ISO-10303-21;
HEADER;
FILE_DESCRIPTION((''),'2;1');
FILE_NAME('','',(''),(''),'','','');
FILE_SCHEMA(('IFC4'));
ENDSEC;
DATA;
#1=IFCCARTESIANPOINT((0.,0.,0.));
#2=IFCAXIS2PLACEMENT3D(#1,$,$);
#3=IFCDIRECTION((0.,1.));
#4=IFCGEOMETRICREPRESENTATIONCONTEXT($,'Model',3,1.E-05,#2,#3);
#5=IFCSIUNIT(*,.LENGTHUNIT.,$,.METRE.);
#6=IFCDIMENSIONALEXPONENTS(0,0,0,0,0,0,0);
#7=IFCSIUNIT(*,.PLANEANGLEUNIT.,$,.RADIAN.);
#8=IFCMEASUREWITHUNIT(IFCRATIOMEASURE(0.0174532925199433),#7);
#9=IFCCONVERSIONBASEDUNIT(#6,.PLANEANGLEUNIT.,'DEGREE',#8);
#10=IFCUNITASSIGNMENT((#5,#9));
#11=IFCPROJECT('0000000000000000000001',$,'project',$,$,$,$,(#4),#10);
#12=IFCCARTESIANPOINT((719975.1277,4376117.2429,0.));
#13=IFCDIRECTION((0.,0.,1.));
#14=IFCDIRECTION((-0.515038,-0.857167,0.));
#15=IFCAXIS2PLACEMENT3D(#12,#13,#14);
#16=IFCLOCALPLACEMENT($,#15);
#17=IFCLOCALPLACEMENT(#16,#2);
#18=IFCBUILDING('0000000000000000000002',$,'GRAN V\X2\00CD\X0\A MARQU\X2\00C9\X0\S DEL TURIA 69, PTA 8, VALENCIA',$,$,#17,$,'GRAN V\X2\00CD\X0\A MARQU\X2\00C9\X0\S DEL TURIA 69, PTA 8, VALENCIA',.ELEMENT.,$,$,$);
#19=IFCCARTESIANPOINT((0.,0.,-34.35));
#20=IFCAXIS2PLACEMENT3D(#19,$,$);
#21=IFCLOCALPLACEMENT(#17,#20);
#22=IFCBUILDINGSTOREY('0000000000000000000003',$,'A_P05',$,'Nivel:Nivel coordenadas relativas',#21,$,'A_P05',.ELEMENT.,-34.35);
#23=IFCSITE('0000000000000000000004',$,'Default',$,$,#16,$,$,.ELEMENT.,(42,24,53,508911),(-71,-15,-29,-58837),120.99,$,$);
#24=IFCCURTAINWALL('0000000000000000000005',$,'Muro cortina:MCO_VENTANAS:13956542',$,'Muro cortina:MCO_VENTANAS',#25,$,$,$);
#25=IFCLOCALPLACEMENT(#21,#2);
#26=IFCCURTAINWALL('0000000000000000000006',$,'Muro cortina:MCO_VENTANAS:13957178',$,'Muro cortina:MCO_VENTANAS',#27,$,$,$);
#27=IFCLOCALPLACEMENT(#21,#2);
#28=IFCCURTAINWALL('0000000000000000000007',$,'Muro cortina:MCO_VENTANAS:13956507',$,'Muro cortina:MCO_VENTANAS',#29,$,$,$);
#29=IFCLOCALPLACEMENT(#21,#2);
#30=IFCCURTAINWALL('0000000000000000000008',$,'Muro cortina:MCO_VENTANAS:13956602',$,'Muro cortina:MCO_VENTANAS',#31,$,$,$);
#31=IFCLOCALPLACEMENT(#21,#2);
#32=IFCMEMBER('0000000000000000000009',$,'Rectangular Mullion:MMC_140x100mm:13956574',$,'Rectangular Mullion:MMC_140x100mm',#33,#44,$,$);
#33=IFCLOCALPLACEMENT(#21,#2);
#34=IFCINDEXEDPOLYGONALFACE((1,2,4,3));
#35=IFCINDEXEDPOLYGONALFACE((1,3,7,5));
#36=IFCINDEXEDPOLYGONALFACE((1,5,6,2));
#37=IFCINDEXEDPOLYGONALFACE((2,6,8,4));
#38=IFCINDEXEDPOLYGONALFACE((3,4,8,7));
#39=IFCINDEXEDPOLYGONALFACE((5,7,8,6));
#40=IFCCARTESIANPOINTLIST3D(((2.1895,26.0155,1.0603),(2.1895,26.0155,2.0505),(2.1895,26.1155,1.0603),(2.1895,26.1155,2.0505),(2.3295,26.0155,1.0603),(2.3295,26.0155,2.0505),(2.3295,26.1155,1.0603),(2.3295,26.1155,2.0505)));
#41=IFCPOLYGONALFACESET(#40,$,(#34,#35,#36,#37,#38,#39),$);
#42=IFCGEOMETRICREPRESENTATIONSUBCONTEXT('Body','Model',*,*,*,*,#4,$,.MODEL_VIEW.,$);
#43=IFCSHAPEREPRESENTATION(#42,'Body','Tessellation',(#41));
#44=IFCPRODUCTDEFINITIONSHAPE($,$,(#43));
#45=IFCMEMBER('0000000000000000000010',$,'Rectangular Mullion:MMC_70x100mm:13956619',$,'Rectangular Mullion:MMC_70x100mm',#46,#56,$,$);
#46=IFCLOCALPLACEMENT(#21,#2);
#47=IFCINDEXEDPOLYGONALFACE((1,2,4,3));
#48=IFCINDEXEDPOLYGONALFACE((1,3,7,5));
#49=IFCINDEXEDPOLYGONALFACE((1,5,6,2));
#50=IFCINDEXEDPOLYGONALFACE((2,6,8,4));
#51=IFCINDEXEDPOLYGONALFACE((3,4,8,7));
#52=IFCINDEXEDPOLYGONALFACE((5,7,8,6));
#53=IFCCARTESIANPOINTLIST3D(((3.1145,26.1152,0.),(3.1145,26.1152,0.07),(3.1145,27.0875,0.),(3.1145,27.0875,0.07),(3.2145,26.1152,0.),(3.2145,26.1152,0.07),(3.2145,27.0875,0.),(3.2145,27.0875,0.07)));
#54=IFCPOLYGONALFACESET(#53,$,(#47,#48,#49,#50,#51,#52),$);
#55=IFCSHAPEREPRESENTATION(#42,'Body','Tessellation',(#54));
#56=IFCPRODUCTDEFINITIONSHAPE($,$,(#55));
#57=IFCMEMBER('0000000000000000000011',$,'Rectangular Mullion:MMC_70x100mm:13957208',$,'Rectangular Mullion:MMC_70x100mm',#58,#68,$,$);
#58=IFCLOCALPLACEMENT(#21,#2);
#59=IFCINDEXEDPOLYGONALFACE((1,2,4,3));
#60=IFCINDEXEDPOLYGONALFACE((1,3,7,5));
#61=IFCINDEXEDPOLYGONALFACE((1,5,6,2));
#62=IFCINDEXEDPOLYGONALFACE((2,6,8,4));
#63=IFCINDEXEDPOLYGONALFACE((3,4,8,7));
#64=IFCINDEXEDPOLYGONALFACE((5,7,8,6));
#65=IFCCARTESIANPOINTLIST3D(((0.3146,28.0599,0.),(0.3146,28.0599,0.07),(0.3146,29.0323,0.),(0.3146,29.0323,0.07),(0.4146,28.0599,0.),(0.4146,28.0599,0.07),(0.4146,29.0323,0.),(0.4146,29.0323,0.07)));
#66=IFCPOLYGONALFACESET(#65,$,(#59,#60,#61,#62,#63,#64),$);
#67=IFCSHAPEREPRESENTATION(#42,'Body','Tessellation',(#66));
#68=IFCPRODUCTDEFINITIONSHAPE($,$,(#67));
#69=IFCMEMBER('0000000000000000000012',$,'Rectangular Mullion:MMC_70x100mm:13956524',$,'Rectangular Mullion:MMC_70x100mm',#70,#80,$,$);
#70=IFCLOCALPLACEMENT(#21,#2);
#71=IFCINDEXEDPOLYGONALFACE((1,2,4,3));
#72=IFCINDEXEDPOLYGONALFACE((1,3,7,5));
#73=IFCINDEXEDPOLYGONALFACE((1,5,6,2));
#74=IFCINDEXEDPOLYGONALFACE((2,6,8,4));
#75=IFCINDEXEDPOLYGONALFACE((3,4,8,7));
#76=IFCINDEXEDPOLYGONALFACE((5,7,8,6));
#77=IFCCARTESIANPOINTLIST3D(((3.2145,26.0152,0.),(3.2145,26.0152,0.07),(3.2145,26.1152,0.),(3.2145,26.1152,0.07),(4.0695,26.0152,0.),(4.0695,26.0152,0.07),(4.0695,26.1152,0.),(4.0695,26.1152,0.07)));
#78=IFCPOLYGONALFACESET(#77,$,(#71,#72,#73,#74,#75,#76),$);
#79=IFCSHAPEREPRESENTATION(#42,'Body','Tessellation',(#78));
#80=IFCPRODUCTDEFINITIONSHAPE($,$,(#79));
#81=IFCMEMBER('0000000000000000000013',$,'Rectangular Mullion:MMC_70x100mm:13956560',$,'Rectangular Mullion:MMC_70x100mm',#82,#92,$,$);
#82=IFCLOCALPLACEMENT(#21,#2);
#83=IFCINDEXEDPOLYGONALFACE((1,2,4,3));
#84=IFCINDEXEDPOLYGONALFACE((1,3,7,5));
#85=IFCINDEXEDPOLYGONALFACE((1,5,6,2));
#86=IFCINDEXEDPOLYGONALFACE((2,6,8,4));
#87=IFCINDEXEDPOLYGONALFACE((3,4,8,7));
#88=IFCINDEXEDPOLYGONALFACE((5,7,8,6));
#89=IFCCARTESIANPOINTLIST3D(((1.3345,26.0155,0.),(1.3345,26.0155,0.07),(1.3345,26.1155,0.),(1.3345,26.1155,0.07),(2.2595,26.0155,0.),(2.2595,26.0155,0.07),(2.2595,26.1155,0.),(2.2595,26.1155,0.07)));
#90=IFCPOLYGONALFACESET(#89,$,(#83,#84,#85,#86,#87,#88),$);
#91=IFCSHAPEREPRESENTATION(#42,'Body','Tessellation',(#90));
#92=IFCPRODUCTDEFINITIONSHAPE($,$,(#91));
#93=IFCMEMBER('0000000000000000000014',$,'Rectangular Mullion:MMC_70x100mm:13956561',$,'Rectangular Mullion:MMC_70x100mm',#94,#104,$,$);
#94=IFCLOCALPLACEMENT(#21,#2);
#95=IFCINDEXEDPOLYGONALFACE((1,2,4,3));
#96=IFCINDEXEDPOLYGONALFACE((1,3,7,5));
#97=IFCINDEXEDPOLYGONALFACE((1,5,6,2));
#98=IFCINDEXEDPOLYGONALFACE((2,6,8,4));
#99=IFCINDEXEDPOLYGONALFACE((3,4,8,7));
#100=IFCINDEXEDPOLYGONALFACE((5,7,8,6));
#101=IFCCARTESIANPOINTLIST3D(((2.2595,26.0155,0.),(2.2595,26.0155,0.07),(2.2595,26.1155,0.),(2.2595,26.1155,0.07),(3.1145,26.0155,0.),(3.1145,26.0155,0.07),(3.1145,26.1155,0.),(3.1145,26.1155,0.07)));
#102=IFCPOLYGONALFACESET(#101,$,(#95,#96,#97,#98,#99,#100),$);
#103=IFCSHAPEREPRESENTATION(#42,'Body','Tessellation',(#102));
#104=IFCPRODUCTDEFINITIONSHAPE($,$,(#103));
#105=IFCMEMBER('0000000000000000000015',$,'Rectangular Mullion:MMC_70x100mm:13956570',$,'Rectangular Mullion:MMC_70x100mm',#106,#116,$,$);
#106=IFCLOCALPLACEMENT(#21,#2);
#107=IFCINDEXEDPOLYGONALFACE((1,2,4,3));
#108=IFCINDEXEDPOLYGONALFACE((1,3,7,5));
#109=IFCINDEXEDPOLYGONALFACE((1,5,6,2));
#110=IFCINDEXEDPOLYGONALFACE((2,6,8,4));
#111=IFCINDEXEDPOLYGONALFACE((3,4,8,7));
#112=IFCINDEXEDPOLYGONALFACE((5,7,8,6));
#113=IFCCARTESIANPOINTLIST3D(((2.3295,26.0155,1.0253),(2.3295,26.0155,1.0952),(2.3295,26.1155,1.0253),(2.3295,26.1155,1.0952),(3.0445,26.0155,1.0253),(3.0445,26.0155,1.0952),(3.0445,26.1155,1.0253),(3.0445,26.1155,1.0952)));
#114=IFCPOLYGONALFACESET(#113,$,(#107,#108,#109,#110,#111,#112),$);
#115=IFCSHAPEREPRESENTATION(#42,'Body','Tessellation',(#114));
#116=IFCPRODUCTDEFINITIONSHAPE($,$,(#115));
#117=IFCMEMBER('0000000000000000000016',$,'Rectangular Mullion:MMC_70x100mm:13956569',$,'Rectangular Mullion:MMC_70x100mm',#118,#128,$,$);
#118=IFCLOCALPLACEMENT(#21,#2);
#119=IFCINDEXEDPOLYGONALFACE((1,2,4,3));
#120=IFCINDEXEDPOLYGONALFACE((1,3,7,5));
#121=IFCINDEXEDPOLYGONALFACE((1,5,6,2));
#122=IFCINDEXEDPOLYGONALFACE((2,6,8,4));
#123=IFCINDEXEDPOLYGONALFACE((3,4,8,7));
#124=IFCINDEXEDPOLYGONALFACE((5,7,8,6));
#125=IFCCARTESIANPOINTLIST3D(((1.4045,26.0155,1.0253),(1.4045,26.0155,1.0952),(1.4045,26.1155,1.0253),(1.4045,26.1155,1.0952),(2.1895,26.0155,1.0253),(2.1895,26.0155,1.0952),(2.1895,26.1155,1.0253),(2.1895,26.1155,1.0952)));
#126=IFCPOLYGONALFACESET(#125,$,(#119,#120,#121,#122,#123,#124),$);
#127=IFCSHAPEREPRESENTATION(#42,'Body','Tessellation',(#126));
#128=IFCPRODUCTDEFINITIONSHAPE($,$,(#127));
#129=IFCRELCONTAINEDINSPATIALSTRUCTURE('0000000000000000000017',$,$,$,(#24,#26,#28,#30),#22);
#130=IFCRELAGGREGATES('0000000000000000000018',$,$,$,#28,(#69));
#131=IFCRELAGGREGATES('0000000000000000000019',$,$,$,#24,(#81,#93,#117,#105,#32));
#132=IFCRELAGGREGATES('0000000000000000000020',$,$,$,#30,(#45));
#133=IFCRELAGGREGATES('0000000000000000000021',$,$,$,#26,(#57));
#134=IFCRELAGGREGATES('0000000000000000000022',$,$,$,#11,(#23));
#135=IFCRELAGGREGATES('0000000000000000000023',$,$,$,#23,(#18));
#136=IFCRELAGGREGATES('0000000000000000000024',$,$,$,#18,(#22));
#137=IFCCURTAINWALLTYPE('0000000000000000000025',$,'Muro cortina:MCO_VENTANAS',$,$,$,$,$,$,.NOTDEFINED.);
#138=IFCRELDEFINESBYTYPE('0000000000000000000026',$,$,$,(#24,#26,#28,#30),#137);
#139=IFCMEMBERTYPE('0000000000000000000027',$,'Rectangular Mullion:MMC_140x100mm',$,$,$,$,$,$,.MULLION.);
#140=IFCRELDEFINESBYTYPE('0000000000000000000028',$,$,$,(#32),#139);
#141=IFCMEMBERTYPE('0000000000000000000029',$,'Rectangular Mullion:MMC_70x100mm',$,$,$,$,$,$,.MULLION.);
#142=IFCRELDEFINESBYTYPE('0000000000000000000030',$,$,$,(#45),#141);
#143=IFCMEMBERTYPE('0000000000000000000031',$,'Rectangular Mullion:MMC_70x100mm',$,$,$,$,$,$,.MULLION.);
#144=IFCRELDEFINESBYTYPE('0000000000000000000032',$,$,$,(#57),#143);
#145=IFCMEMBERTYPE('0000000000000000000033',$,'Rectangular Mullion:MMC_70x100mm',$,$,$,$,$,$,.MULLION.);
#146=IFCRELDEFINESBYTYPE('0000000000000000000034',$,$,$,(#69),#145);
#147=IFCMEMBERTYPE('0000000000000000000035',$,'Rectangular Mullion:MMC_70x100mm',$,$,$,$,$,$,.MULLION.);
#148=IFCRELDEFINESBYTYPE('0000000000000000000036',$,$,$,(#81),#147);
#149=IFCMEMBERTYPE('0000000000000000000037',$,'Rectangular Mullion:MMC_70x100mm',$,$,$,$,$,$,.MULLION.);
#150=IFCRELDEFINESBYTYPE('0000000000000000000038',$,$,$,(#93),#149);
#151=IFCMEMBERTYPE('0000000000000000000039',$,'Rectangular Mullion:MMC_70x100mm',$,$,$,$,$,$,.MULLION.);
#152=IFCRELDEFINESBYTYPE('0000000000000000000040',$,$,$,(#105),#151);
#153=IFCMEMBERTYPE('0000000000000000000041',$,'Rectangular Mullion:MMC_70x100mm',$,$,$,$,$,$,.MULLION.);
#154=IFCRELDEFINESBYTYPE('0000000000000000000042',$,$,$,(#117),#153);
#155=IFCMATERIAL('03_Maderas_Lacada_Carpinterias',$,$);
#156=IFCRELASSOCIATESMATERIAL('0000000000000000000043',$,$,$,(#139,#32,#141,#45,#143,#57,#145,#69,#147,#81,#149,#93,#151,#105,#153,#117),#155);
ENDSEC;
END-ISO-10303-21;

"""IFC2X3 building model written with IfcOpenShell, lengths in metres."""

from ifc_helpers import new_model, entity, si_unit, converted_unit, direction, frame, origin, origin_2d_with_axis, place, context, subcontext, project, spatial, rectangle, extrude, source, transform, mapped, material, type_object, type_shapes, element, aggregate, save


model = new_model("IFC2X3")

# Units and contexts
model_context = context("Model", 3, precision=1e-05, world=origin(), true_north=direction((0.0, 1.0)))
body_context = subcontext(model_context, "Body", "Model", "MODEL_VIEW")
ifc_project = project(units=[si_unit("LENGTHUNIT", "METRE"), converted_unit("PLANEANGLEUNIT", "DEGREE", entity("IfcRatioMeasure", 0.0174532925199433), si_unit("PLANEANGLEUNIT", "RADIAN"), dimensions=[0, 0, 0, 0, 0, 0, 0])], contexts=[model_context])

# Site, building, storey
site_placement = place(None, frame((719975.1277, 4376117.2429, 0.0), z_axis=(0.0, 0.0, 1.0), x_axis=(-0.515038, -0.857167, 0.0)))
site = spatial("IfcSite", under=ifc_project, at=site_placement, Name="Default", CompositionType="ELEMENT", RefLatitude=(42, 24, 53, 508911), RefLongitude=(-71, -15, -29, -58837), RefElevation=120.99)
building_placement = place(site_placement, origin())
building = spatial("IfcBuilding", under=site, at=building_placement, Name="GRAN VÍA MARQUÉS DEL TURIA 69, PTA 8, VALENCIA", LongName="GRAN VÍA MARQUÉS DEL TURIA 69, PTA 8, VALENCIA", CompositionType="ELEMENT")
storey_placement = place(building_placement, frame((0.0, 0.0, -34.35)))
storey = spatial("IfcBuildingStorey", under=building, at=storey_placement, Name="A_P05", ObjectType="Nivel:Nivel coordenadas relativas", LongName="A_P05", CompositionType="ELEMENT", Elevation=-34.35)

# Shared definitions
curtain_wall_type = type_object("IfcCurtainWallType", Name="Muro cortina:MCO_VENTANAS", PredefinedType="NOTDEFINED")
ifc_material_1 = material(Name="03_Maderas_Lacada_Carpinterias")

# Curtain walls
curtain_wall_1_placement = place(storey_placement, frame((0.0, 0.0, 34.35)))
curtain_wall_1 = element("IfcCurtainWall", 1, at=curtain_wall_1_placement, inside=storey, type_object=curtain_wall_type, Name="Muro cortina:MCO_VENTANAS:13956542", ObjectType="Muro cortina:MCO_VENTANAS")
curtain_wall_2_placement = place(storey_placement, frame((0.0, 0.0, 34.35)))
curtain_wall_2 = element("IfcCurtainWall", 2, at=curtain_wall_2_placement, inside=storey, type_object=curtain_wall_type, Name="Muro cortina:MCO_VENTANAS:13957178", ObjectType="Muro cortina:MCO_VENTANAS")
curtain_wall_3_placement = place(storey_placement, frame((0.0, 0.0, 34.35)))
curtain_wall_3 = element("IfcCurtainWall", 3, at=curtain_wall_3_placement, inside=storey, type_object=curtain_wall_type, Name="Muro cortina:MCO_VENTANAS:13956507", ObjectType="Muro cortina:MCO_VENTANAS")
curtain_wall_4_placement = place(storey_placement, frame((0.0, 0.0, 34.35)))
curtain_wall_4 = element("IfcCurtainWall", 4, at=curtain_wall_4_placement, inside=storey, type_object=curtain_wall_type, Name="Muro cortina:MCO_VENTANAS:13956602", ObjectType="Muro cortina:MCO_VENTANAS")

# Members
member_type_1 = type_object("IfcMemberType", Name="Rectangular Mullion:MMC_140x100mm", PredefinedType="MULLION", material=ifc_material_1)
shared_shape_1 = source(origin(), body_context, "Body", "SweptSolid", [
    extrude(rectangle(XDim=0.1, YDim=0.14, at=origin_2d_with_axis()), frame((0.0, 0.0, -0.9902), z_axis=(0.0, 0.0, 1.0), x_axis=(0.0, -1.0, 0.0)), (0.0, 0.0, 1.0), 0.9902),
])
type_shapes(member_type_1, [shared_shape_1])
member_1_placement = place(storey_placement, frame((2.2595, 26.0655, 1.0602), z_axis=(0.0, 0.0, -1.0), x_axis=(1.0, 0.00001, 0.0)))
member_1 = element("IfcMember", 5, at=member_1_placement, type_object=member_type_1, material=ifc_material_1, Name="Rectangular Mullion:MMC_140x100mm:13956574", ObjectType="Rectangular Mullion:MMC_140x100mm", context=body_context, shape_type="MappedRepresentation", body=[
    mapped(shared_shape_1, transform((0.0, 0.0, 0.0), scale=1.0)),
])
member_type_2 = type_object("IfcMemberType", Name="Rectangular Mullion:MMC_70x100mm", PredefinedType="MULLION", material=ifc_material_1)
shared_shape_2 = source(origin(), body_context, "Body", "SweptSolid", [
    extrude(rectangle(XDim=0.1, YDim=0.07, at=origin_2d_with_axis()), frame((-0.035, 0.0, -0.9723), z_axis=(0.0, 0.0, 1.0), x_axis=(0.0, -1.0, 0.0)), (0.0, 0.0, 1.0), 0.9723),
])
type_shapes(member_type_2, [shared_shape_2])
member_2_placement = place(storey_placement, frame((3.1645, 26.1152, 0.0), z_axis=(0.00001, -1.0, 0.0), x_axis=(0.0, 0.0, -1.0)))
member_2 = element("IfcMember", 6, at=member_2_placement, type_object=member_type_2, material=ifc_material_1, Name="Rectangular Mullion:MMC_70x100mm:13956619", ObjectType="Rectangular Mullion:MMC_70x100mm", context=body_context, shape_type="MappedRepresentation", body=[
    mapped(shared_shape_2, transform((0.0, 0.0, 0.0), scale=1.0)),
])
member_type_3 = type_object("IfcMemberType", Name="Rectangular Mullion:MMC_70x100mm", PredefinedType="MULLION", material=ifc_material_1)
shared_shape_3 = source(origin(), body_context, "Body", "SweptSolid", [
    extrude(rectangle(XDim=0.1, YDim=0.07, at=origin_2d_with_axis()), frame((-0.035, 0.0, -0.9723), z_axis=(0.0, 0.0, 1.0), x_axis=(0.0, -1.0, 0.0)), (0.0, 0.0, 1.0), 0.9723),
])
type_shapes(member_type_3, [shared_shape_3])
member_3_placement = place(storey_placement, frame((0.3646, 28.0599, 0.0), z_axis=(0.0, -1.0, 0.0), x_axis=(0.0, 0.0, -1.0)))
member_3 = element("IfcMember", 7, at=member_3_placement, type_object=member_type_3, material=ifc_material_1, Name="Rectangular Mullion:MMC_70x100mm:13957208", ObjectType="Rectangular Mullion:MMC_70x100mm", context=body_context, shape_type="MappedRepresentation", body=[
    mapped(shared_shape_3, transform((0.0, 0.0, 0.0), scale=1.0)),
])
member_type_4 = type_object("IfcMemberType", Name="Rectangular Mullion:MMC_70x100mm", PredefinedType="MULLION", material=ifc_material_1)
shared_shape_4 = source(origin(), body_context, "Body", "SweptSolid", [
    extrude(rectangle(XDim=0.1, YDim=0.07, at=origin_2d_with_axis()), frame((-0.035, 0.0, -0.855), z_axis=(0.0, 0.0, 1.0), x_axis=(0.0, -1.0, 0.0)), (0.0, 0.0, 1.0), 0.855),
])
type_shapes(member_type_4, [shared_shape_4])
member_4_placement = place(storey_placement, frame((3.2145, 26.0652, 0.0), z_axis=(-1.0, -0.00001, 0.0), x_axis=(0.0, 0.0, -1.0)))
member_4 = element("IfcMember", 8, at=member_4_placement, type_object=member_type_4, material=ifc_material_1, Name="Rectangular Mullion:MMC_70x100mm:13956524", ObjectType="Rectangular Mullion:MMC_70x100mm", context=body_context, shape_type="MappedRepresentation", body=[
    mapped(shared_shape_4, transform((0.0, 0.0, 0.0), scale=1.0)),
])
member_type_5 = type_object("IfcMemberType", Name="Rectangular Mullion:MMC_70x100mm", PredefinedType="MULLION", material=ifc_material_1)
shared_shape_5 = source(origin(), body_context, "Body", "SweptSolid", [
    extrude(rectangle(XDim=0.1, YDim=0.07, at=origin_2d_with_axis()), frame((-0.035, 0.0, -0.925), z_axis=(0.0, 0.0, 1.0), x_axis=(0.0, -1.0, 0.0)), (0.0, 0.0, 1.0), 0.925),
])
type_shapes(member_type_5, [shared_shape_5])
member_5_placement = place(storey_placement, frame((1.3345, 26.0655, 0.0), z_axis=(-1.0, -0.00001, 0.0), x_axis=(0.0, 0.0, -1.0)))
member_5 = element("IfcMember", 9, at=member_5_placement, type_object=member_type_5, material=ifc_material_1, Name="Rectangular Mullion:MMC_70x100mm:13956560", ObjectType="Rectangular Mullion:MMC_70x100mm", context=body_context, shape_type="MappedRepresentation", body=[
    mapped(shared_shape_5, transform((0.0, 0.0, 0.0), scale=1.0)),
])
member_type_6 = type_object("IfcMemberType", Name="Rectangular Mullion:MMC_70x100mm", PredefinedType="MULLION", material=ifc_material_1)
shared_shape_6 = source(origin(), body_context, "Body", "SweptSolid", [
    extrude(rectangle(XDim=0.1, YDim=0.07, at=origin_2d_with_axis()), frame((-0.035, 0.0, -0.855), z_axis=(0.0, 0.0, 1.0), x_axis=(0.0, -1.0, 0.0)), (0.0, 0.0, 1.0), 0.855),
])
type_shapes(member_type_6, [shared_shape_6])
member_6_placement = place(storey_placement, frame((2.2595, 26.0655, 0.0), z_axis=(-1.0, -0.00001, 0.0), x_axis=(0.0, 0.0, -1.0)))
member_6 = element("IfcMember", 10, at=member_6_placement, type_object=member_type_6, material=ifc_material_1, Name="Rectangular Mullion:MMC_70x100mm:13956561", ObjectType="Rectangular Mullion:MMC_70x100mm", context=body_context, shape_type="MappedRepresentation", body=[
    mapped(shared_shape_6, transform((0.0, 0.0, 0.0), scale=1.0)),
])
member_type_7 = type_object("IfcMemberType", Name="Rectangular Mullion:MMC_70x100mm", PredefinedType="MULLION", material=ifc_material_1)
shared_shape_7 = source(origin(), body_context, "Body", "SweptSolid", [
    extrude(rectangle(XDim=0.1, YDim=0.07, at=origin_2d_with_axis()), frame((0.0, 0.0, -0.715), z_axis=(0.0, 0.0, 1.0), x_axis=(0.0, -1.0, 0.0)), (0.0, 0.0, 1.0), 0.715),
])
type_shapes(member_type_7, [shared_shape_7])
member_7_placement = place(storey_placement, frame((3.0445, 26.0655, 1.0602), z_axis=(1.0, 0.00001, 0.0), x_axis=(0.0, 0.0, 1.0)))
member_7 = element("IfcMember", 11, at=member_7_placement, type_object=member_type_7, material=ifc_material_1, Name="Rectangular Mullion:MMC_70x100mm:13956570", ObjectType="Rectangular Mullion:MMC_70x100mm", context=body_context, shape_type="MappedRepresentation", body=[
    mapped(shared_shape_7, transform((0.0, 0.0, 0.0), scale=1.0)),
])
member_type_8 = type_object("IfcMemberType", Name="Rectangular Mullion:MMC_70x100mm", PredefinedType="MULLION", material=ifc_material_1)
shared_shape_8 = source(origin(), body_context, "Body", "SweptSolid", [
    extrude(rectangle(XDim=0.1, YDim=0.07, at=origin_2d_with_axis()), frame((0.0, 0.0, -0.785), z_axis=(0.0, 0.0, 1.0), x_axis=(0.0, -1.0, 0.0)), (0.0, 0.0, 1.0), 0.785),
])
type_shapes(member_type_8, [shared_shape_8])
member_8_placement = place(storey_placement, frame((2.1895, 26.0655, 1.0602), z_axis=(1.0, 0.00001, 0.0), x_axis=(0.0, 0.0, 1.0)))
member_8 = element("IfcMember", 12, at=member_8_placement, type_object=member_type_8, material=ifc_material_1, Name="Rectangular Mullion:MMC_70x100mm:13956569", ObjectType="Rectangular Mullion:MMC_70x100mm", context=body_context, shape_type="MappedRepresentation", body=[
    mapped(shared_shape_8, transform((0.0, 0.0, 0.0), scale=1.0)),
])

aggregate(curtain_wall_3, [member_4])
aggregate(curtain_wall_1, [member_5, member_6, member_8, member_7, member_1])
aggregate(curtain_wall_4, [member_2])
aggregate(curtain_wall_2, [member_3])

save(model, "model.ifc")
